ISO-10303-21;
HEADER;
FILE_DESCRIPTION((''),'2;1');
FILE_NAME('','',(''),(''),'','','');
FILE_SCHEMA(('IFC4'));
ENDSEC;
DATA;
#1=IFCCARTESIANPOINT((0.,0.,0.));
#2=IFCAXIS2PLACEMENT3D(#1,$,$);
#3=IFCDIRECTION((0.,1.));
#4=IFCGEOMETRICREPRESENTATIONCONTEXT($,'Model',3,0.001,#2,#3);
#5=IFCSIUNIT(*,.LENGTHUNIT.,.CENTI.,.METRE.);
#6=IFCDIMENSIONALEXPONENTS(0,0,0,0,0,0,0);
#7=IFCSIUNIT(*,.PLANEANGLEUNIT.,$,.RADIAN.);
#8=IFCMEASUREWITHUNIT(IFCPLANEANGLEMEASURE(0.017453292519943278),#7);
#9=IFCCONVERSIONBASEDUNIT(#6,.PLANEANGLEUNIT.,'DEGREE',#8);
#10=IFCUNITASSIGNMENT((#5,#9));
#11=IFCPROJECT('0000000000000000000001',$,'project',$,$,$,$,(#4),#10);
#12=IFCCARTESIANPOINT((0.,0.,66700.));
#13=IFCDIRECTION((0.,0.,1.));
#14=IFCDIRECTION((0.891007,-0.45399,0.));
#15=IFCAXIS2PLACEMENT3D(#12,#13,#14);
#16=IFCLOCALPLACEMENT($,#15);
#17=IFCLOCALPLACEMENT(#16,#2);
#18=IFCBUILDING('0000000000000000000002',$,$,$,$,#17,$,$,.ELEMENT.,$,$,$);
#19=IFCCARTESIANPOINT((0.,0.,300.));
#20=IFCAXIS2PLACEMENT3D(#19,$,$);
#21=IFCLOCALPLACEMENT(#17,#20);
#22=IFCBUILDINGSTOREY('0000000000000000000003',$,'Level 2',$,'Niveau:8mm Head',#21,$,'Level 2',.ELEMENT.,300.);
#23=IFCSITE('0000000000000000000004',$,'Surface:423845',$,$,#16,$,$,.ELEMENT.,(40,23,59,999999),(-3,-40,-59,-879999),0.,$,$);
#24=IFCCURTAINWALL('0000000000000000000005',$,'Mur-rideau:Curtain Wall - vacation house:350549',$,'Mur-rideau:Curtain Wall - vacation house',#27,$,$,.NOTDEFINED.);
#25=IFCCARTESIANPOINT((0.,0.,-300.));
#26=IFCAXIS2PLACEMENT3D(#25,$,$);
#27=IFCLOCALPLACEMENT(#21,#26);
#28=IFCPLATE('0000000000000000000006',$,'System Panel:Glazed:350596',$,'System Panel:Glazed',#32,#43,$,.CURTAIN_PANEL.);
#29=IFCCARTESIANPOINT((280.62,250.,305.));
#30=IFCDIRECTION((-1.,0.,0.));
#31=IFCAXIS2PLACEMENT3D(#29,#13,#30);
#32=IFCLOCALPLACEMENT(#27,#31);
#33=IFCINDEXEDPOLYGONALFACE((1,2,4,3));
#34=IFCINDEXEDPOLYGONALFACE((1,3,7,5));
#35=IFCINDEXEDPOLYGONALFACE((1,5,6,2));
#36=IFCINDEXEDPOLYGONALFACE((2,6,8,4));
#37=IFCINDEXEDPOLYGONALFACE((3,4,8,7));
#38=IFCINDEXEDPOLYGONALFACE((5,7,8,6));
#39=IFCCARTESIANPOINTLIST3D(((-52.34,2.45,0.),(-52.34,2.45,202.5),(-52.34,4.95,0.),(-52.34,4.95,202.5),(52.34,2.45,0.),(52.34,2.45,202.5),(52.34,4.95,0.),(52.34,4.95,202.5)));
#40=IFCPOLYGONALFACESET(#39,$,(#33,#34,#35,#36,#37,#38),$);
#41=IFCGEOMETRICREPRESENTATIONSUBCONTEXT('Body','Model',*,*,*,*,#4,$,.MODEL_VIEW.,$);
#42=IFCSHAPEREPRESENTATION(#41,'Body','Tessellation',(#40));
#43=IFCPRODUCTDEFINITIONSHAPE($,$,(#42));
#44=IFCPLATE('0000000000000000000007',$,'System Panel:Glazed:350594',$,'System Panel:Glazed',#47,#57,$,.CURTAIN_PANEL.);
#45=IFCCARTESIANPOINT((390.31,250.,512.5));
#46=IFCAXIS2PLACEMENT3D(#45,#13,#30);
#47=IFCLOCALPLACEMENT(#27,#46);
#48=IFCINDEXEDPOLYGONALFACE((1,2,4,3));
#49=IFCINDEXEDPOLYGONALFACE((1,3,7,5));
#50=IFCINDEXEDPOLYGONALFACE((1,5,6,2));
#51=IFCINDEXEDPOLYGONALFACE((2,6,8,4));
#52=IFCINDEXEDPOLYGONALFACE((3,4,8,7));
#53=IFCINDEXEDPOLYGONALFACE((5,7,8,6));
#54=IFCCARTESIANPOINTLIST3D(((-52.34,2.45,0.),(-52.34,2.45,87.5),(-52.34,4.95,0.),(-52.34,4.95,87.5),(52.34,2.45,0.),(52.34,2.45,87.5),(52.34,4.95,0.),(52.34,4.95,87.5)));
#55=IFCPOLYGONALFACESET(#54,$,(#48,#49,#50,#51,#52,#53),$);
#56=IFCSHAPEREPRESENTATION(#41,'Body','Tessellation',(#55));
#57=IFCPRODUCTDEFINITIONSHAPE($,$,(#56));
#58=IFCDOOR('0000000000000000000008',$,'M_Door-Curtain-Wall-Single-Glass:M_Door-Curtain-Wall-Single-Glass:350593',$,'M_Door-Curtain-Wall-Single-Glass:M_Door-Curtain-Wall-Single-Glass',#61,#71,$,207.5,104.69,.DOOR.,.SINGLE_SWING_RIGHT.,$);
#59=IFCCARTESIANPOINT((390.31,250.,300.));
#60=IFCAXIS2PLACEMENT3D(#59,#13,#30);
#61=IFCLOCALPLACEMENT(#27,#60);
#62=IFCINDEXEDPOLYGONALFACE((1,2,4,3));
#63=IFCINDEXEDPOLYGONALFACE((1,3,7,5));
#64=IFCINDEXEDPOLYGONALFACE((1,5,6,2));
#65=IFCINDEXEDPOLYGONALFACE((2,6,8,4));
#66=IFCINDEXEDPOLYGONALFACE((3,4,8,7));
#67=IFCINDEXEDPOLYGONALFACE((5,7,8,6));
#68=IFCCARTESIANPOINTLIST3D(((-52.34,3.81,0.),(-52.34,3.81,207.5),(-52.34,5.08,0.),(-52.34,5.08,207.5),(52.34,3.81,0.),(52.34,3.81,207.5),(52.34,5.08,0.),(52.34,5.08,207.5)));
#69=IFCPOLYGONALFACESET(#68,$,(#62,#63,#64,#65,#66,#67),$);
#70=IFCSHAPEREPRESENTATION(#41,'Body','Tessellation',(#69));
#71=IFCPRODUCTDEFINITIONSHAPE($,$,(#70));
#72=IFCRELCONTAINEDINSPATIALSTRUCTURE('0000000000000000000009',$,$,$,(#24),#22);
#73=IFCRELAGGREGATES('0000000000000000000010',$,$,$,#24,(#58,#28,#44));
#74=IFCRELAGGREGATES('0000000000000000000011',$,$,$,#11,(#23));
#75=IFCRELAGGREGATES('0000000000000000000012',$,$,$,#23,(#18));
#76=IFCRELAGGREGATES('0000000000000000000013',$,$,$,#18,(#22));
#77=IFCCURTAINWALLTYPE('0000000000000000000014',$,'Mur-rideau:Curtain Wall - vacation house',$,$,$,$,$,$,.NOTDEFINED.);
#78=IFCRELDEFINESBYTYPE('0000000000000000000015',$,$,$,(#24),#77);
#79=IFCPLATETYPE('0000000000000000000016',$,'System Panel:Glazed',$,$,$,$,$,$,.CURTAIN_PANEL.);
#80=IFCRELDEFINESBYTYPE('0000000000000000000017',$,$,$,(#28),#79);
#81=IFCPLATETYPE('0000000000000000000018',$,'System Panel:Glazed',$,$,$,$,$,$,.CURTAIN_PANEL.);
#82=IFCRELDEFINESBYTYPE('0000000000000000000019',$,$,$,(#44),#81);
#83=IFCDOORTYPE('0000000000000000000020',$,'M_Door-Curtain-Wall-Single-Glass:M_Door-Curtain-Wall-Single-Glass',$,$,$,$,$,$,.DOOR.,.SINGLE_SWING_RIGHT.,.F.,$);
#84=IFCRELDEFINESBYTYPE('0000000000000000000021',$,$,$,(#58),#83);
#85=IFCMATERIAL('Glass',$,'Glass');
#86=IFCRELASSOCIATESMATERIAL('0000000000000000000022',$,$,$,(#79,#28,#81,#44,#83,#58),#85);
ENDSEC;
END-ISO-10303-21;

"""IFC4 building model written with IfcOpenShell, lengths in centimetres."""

from ifc_helpers import new_model, entity, si_unit, converted_unit, direction, frame, frame_2d, origin, origin_2d_with_axis, place, context, subcontext, project, spatial, rectangle, extrude, source, transform, mapped, material, type_object, type_shapes, element, aggregate, save


model = new_model("IFC4")

# Units and contexts
model_context = context("Model", 3, precision=0.001, world=origin(), true_north=direction((0.0, 1.0)))
body_context = subcontext(model_context, "Body", "Model", "MODEL_VIEW")
ifc_project = project(units=[si_unit("LENGTHUNIT", "METRE", prefix="CENTI"), converted_unit("PLANEANGLEUNIT", "DEGREE", entity("IfcPlaneAngleMeasure", 0.017453292519943278), si_unit("PLANEANGLEUNIT", "RADIAN"), dimensions=[0, 0, 0, 0, 0, 0, 0])], contexts=[model_context])

# Site, building, storey
site_placement = place(None, frame((0.0, 0.0, 66700.0), z_axis=(0.0, 0.0, 1.0), x_axis=(0.891007, -0.45399, 0.0)))
site = spatial("IfcSite", under=ifc_project, at=site_placement, Name="Surface:423845", CompositionType="ELEMENT", RefLatitude=(40, 23, 59, 999999), RefLongitude=(-3, -40, -59, -879999), RefElevation=0.0)
building_placement = place(site_placement, origin())
building = spatial("IfcBuilding", under=site, at=building_placement, CompositionType="ELEMENT")
storey_placement = place(building_placement, frame((0.0, 0.0, 300.0)))
storey = spatial("IfcBuildingStorey", under=building, at=storey_placement, Name="Level 2", ObjectType="Niveau:8mm Head", LongName="Level 2", CompositionType="ELEMENT", Elevation=300.0)

# Curtain wall
curtain_wall_type = type_object("IfcCurtainWallType", Name="Mur-rideau:Curtain Wall - vacation house", PredefinedType="NOTDEFINED")
curtain_wall_placement = place(storey_placement, frame((0.0, 0.0, -300.0)))
curtain_wall = element("IfcCurtainWall", 1, at=curtain_wall_placement, inside=storey, type_object=curtain_wall_type, Name="Mur-rideau:Curtain Wall - vacation house:350549", ObjectType="Mur-rideau:Curtain Wall - vacation house", PredefinedType="NOTDEFINED")

# Plates
ifc_material_1 = material(Name="Glass", Category="Glass")
plate_type_1 = type_object("IfcPlateType", Name="System Panel:Glazed", PredefinedType="CURTAIN_PANEL", material=ifc_material_1)
shared_shape_1 = source(origin(), body_context, "Body", "SweptSolid", [
    extrude(rectangle(XDim=2.5, YDim=104.69, at=origin_2d_with_axis()), frame((0.0, 3.7, 0.0), z_axis=(0.0, 0.0, 1.0), x_axis=(0.0, 1.0, 0.0)), (0.0, 0.0, 1.0), 202.5),
])
type_shapes(plate_type_1, [shared_shape_1])
plate_1_placement = place(curtain_wall_placement, frame((280.62, 250.0, 305.0), z_axis=(0.0, 0.0, 1.0), x_axis=(-1.0, 0.0, 0.0)))
plate_1 = element("IfcPlate", 2, at=plate_1_placement, type_object=plate_type_1, material=ifc_material_1, Name="System Panel:Glazed:350596", ObjectType="System Panel:Glazed", PredefinedType="CURTAIN_PANEL", context=body_context, shape_type="MappedRepresentation", body=[
    mapped(shared_shape_1, transform((0.0, 0.0, 0.0), scale=1.0)),
])
plate_type_2 = type_object("IfcPlateType", Name="System Panel:Glazed", PredefinedType="CURTAIN_PANEL", material=ifc_material_1)
shared_shape_2 = source(origin(), body_context, "Body", "SweptSolid", [
    extrude(rectangle(XDim=2.5, YDim=104.69, at=origin_2d_with_axis()), frame((0.0, 3.7, 0.0), z_axis=(0.0, 0.0, 1.0), x_axis=(0.0, 1.0, 0.0)), (0.0, 0.0, 1.0), 87.5),
])
type_shapes(plate_type_2, [shared_shape_2])
plate_2_placement = place(curtain_wall_placement, frame((390.31, 250.0, 512.5), z_axis=(0.0, 0.0, 1.0), x_axis=(-1.0, 0.0, 0.0)))
plate_2 = element("IfcPlate", 3, at=plate_2_placement, type_object=plate_type_2, material=ifc_material_1, Name="System Panel:Glazed:350594", ObjectType="System Panel:Glazed", PredefinedType="CURTAIN_PANEL", context=body_context, shape_type="MappedRepresentation", body=[
    mapped(shared_shape_2, transform((0.0, 0.0, 0.0), scale=1.0)),
])

# Door
door_type_1 = type_object("IfcDoorType", Name="M_Door-Curtain-Wall-Single-Glass:M_Door-Curtain-Wall-Single-Glass", OperationType="SINGLE_SWING_RIGHT", ParameterTakesPrecedence=False, PredefinedType="DOOR", material=ifc_material_1)
shared_shape_3 = source(origin(), body_context, "Body", "SweptSolid", [
    extrude(rectangle(XDim=104.69, YDim=1.27, at=frame_2d((0.0, 0.0), x_axis=(1.0, 0.0))), frame((0.0, 4.45, 0.0), z_axis=(0.0, 0.0, 1.0), x_axis=(-1.0, 0.0, 0.0)), (0.0, 0.0, 1.0), 207.5),
])
type_shapes(door_type_1, [shared_shape_3])
door_1_placement = place(curtain_wall_placement, frame((390.31, 250.0, 300.0), z_axis=(0.0, 0.0, 1.0), x_axis=(-1.0, 0.0, 0.0)))
door_1 = element("IfcDoor", 4, at=door_1_placement, type_object=door_type_1, material=ifc_material_1, Name="M_Door-Curtain-Wall-Single-Glass:M_Door-Curtain-Wall-Single-Glass:350593", ObjectType="M_Door-Curtain-Wall-Single-Glass:M_Door-Curtain-Wall-Single-Glass", OperationType="SINGLE_SWING_RIGHT", OverallHeight=207.5, OverallWidth=104.69, PredefinedType="DOOR", context=body_context, shape_type="MappedRepresentation", body=[
    mapped(shared_shape_3, transform((0.0, 0.0, 0.0), scale=1.0)),
])
aggregate(curtain_wall, [door_1, plate_1, plate_2])

save(model, "model.ifc")
